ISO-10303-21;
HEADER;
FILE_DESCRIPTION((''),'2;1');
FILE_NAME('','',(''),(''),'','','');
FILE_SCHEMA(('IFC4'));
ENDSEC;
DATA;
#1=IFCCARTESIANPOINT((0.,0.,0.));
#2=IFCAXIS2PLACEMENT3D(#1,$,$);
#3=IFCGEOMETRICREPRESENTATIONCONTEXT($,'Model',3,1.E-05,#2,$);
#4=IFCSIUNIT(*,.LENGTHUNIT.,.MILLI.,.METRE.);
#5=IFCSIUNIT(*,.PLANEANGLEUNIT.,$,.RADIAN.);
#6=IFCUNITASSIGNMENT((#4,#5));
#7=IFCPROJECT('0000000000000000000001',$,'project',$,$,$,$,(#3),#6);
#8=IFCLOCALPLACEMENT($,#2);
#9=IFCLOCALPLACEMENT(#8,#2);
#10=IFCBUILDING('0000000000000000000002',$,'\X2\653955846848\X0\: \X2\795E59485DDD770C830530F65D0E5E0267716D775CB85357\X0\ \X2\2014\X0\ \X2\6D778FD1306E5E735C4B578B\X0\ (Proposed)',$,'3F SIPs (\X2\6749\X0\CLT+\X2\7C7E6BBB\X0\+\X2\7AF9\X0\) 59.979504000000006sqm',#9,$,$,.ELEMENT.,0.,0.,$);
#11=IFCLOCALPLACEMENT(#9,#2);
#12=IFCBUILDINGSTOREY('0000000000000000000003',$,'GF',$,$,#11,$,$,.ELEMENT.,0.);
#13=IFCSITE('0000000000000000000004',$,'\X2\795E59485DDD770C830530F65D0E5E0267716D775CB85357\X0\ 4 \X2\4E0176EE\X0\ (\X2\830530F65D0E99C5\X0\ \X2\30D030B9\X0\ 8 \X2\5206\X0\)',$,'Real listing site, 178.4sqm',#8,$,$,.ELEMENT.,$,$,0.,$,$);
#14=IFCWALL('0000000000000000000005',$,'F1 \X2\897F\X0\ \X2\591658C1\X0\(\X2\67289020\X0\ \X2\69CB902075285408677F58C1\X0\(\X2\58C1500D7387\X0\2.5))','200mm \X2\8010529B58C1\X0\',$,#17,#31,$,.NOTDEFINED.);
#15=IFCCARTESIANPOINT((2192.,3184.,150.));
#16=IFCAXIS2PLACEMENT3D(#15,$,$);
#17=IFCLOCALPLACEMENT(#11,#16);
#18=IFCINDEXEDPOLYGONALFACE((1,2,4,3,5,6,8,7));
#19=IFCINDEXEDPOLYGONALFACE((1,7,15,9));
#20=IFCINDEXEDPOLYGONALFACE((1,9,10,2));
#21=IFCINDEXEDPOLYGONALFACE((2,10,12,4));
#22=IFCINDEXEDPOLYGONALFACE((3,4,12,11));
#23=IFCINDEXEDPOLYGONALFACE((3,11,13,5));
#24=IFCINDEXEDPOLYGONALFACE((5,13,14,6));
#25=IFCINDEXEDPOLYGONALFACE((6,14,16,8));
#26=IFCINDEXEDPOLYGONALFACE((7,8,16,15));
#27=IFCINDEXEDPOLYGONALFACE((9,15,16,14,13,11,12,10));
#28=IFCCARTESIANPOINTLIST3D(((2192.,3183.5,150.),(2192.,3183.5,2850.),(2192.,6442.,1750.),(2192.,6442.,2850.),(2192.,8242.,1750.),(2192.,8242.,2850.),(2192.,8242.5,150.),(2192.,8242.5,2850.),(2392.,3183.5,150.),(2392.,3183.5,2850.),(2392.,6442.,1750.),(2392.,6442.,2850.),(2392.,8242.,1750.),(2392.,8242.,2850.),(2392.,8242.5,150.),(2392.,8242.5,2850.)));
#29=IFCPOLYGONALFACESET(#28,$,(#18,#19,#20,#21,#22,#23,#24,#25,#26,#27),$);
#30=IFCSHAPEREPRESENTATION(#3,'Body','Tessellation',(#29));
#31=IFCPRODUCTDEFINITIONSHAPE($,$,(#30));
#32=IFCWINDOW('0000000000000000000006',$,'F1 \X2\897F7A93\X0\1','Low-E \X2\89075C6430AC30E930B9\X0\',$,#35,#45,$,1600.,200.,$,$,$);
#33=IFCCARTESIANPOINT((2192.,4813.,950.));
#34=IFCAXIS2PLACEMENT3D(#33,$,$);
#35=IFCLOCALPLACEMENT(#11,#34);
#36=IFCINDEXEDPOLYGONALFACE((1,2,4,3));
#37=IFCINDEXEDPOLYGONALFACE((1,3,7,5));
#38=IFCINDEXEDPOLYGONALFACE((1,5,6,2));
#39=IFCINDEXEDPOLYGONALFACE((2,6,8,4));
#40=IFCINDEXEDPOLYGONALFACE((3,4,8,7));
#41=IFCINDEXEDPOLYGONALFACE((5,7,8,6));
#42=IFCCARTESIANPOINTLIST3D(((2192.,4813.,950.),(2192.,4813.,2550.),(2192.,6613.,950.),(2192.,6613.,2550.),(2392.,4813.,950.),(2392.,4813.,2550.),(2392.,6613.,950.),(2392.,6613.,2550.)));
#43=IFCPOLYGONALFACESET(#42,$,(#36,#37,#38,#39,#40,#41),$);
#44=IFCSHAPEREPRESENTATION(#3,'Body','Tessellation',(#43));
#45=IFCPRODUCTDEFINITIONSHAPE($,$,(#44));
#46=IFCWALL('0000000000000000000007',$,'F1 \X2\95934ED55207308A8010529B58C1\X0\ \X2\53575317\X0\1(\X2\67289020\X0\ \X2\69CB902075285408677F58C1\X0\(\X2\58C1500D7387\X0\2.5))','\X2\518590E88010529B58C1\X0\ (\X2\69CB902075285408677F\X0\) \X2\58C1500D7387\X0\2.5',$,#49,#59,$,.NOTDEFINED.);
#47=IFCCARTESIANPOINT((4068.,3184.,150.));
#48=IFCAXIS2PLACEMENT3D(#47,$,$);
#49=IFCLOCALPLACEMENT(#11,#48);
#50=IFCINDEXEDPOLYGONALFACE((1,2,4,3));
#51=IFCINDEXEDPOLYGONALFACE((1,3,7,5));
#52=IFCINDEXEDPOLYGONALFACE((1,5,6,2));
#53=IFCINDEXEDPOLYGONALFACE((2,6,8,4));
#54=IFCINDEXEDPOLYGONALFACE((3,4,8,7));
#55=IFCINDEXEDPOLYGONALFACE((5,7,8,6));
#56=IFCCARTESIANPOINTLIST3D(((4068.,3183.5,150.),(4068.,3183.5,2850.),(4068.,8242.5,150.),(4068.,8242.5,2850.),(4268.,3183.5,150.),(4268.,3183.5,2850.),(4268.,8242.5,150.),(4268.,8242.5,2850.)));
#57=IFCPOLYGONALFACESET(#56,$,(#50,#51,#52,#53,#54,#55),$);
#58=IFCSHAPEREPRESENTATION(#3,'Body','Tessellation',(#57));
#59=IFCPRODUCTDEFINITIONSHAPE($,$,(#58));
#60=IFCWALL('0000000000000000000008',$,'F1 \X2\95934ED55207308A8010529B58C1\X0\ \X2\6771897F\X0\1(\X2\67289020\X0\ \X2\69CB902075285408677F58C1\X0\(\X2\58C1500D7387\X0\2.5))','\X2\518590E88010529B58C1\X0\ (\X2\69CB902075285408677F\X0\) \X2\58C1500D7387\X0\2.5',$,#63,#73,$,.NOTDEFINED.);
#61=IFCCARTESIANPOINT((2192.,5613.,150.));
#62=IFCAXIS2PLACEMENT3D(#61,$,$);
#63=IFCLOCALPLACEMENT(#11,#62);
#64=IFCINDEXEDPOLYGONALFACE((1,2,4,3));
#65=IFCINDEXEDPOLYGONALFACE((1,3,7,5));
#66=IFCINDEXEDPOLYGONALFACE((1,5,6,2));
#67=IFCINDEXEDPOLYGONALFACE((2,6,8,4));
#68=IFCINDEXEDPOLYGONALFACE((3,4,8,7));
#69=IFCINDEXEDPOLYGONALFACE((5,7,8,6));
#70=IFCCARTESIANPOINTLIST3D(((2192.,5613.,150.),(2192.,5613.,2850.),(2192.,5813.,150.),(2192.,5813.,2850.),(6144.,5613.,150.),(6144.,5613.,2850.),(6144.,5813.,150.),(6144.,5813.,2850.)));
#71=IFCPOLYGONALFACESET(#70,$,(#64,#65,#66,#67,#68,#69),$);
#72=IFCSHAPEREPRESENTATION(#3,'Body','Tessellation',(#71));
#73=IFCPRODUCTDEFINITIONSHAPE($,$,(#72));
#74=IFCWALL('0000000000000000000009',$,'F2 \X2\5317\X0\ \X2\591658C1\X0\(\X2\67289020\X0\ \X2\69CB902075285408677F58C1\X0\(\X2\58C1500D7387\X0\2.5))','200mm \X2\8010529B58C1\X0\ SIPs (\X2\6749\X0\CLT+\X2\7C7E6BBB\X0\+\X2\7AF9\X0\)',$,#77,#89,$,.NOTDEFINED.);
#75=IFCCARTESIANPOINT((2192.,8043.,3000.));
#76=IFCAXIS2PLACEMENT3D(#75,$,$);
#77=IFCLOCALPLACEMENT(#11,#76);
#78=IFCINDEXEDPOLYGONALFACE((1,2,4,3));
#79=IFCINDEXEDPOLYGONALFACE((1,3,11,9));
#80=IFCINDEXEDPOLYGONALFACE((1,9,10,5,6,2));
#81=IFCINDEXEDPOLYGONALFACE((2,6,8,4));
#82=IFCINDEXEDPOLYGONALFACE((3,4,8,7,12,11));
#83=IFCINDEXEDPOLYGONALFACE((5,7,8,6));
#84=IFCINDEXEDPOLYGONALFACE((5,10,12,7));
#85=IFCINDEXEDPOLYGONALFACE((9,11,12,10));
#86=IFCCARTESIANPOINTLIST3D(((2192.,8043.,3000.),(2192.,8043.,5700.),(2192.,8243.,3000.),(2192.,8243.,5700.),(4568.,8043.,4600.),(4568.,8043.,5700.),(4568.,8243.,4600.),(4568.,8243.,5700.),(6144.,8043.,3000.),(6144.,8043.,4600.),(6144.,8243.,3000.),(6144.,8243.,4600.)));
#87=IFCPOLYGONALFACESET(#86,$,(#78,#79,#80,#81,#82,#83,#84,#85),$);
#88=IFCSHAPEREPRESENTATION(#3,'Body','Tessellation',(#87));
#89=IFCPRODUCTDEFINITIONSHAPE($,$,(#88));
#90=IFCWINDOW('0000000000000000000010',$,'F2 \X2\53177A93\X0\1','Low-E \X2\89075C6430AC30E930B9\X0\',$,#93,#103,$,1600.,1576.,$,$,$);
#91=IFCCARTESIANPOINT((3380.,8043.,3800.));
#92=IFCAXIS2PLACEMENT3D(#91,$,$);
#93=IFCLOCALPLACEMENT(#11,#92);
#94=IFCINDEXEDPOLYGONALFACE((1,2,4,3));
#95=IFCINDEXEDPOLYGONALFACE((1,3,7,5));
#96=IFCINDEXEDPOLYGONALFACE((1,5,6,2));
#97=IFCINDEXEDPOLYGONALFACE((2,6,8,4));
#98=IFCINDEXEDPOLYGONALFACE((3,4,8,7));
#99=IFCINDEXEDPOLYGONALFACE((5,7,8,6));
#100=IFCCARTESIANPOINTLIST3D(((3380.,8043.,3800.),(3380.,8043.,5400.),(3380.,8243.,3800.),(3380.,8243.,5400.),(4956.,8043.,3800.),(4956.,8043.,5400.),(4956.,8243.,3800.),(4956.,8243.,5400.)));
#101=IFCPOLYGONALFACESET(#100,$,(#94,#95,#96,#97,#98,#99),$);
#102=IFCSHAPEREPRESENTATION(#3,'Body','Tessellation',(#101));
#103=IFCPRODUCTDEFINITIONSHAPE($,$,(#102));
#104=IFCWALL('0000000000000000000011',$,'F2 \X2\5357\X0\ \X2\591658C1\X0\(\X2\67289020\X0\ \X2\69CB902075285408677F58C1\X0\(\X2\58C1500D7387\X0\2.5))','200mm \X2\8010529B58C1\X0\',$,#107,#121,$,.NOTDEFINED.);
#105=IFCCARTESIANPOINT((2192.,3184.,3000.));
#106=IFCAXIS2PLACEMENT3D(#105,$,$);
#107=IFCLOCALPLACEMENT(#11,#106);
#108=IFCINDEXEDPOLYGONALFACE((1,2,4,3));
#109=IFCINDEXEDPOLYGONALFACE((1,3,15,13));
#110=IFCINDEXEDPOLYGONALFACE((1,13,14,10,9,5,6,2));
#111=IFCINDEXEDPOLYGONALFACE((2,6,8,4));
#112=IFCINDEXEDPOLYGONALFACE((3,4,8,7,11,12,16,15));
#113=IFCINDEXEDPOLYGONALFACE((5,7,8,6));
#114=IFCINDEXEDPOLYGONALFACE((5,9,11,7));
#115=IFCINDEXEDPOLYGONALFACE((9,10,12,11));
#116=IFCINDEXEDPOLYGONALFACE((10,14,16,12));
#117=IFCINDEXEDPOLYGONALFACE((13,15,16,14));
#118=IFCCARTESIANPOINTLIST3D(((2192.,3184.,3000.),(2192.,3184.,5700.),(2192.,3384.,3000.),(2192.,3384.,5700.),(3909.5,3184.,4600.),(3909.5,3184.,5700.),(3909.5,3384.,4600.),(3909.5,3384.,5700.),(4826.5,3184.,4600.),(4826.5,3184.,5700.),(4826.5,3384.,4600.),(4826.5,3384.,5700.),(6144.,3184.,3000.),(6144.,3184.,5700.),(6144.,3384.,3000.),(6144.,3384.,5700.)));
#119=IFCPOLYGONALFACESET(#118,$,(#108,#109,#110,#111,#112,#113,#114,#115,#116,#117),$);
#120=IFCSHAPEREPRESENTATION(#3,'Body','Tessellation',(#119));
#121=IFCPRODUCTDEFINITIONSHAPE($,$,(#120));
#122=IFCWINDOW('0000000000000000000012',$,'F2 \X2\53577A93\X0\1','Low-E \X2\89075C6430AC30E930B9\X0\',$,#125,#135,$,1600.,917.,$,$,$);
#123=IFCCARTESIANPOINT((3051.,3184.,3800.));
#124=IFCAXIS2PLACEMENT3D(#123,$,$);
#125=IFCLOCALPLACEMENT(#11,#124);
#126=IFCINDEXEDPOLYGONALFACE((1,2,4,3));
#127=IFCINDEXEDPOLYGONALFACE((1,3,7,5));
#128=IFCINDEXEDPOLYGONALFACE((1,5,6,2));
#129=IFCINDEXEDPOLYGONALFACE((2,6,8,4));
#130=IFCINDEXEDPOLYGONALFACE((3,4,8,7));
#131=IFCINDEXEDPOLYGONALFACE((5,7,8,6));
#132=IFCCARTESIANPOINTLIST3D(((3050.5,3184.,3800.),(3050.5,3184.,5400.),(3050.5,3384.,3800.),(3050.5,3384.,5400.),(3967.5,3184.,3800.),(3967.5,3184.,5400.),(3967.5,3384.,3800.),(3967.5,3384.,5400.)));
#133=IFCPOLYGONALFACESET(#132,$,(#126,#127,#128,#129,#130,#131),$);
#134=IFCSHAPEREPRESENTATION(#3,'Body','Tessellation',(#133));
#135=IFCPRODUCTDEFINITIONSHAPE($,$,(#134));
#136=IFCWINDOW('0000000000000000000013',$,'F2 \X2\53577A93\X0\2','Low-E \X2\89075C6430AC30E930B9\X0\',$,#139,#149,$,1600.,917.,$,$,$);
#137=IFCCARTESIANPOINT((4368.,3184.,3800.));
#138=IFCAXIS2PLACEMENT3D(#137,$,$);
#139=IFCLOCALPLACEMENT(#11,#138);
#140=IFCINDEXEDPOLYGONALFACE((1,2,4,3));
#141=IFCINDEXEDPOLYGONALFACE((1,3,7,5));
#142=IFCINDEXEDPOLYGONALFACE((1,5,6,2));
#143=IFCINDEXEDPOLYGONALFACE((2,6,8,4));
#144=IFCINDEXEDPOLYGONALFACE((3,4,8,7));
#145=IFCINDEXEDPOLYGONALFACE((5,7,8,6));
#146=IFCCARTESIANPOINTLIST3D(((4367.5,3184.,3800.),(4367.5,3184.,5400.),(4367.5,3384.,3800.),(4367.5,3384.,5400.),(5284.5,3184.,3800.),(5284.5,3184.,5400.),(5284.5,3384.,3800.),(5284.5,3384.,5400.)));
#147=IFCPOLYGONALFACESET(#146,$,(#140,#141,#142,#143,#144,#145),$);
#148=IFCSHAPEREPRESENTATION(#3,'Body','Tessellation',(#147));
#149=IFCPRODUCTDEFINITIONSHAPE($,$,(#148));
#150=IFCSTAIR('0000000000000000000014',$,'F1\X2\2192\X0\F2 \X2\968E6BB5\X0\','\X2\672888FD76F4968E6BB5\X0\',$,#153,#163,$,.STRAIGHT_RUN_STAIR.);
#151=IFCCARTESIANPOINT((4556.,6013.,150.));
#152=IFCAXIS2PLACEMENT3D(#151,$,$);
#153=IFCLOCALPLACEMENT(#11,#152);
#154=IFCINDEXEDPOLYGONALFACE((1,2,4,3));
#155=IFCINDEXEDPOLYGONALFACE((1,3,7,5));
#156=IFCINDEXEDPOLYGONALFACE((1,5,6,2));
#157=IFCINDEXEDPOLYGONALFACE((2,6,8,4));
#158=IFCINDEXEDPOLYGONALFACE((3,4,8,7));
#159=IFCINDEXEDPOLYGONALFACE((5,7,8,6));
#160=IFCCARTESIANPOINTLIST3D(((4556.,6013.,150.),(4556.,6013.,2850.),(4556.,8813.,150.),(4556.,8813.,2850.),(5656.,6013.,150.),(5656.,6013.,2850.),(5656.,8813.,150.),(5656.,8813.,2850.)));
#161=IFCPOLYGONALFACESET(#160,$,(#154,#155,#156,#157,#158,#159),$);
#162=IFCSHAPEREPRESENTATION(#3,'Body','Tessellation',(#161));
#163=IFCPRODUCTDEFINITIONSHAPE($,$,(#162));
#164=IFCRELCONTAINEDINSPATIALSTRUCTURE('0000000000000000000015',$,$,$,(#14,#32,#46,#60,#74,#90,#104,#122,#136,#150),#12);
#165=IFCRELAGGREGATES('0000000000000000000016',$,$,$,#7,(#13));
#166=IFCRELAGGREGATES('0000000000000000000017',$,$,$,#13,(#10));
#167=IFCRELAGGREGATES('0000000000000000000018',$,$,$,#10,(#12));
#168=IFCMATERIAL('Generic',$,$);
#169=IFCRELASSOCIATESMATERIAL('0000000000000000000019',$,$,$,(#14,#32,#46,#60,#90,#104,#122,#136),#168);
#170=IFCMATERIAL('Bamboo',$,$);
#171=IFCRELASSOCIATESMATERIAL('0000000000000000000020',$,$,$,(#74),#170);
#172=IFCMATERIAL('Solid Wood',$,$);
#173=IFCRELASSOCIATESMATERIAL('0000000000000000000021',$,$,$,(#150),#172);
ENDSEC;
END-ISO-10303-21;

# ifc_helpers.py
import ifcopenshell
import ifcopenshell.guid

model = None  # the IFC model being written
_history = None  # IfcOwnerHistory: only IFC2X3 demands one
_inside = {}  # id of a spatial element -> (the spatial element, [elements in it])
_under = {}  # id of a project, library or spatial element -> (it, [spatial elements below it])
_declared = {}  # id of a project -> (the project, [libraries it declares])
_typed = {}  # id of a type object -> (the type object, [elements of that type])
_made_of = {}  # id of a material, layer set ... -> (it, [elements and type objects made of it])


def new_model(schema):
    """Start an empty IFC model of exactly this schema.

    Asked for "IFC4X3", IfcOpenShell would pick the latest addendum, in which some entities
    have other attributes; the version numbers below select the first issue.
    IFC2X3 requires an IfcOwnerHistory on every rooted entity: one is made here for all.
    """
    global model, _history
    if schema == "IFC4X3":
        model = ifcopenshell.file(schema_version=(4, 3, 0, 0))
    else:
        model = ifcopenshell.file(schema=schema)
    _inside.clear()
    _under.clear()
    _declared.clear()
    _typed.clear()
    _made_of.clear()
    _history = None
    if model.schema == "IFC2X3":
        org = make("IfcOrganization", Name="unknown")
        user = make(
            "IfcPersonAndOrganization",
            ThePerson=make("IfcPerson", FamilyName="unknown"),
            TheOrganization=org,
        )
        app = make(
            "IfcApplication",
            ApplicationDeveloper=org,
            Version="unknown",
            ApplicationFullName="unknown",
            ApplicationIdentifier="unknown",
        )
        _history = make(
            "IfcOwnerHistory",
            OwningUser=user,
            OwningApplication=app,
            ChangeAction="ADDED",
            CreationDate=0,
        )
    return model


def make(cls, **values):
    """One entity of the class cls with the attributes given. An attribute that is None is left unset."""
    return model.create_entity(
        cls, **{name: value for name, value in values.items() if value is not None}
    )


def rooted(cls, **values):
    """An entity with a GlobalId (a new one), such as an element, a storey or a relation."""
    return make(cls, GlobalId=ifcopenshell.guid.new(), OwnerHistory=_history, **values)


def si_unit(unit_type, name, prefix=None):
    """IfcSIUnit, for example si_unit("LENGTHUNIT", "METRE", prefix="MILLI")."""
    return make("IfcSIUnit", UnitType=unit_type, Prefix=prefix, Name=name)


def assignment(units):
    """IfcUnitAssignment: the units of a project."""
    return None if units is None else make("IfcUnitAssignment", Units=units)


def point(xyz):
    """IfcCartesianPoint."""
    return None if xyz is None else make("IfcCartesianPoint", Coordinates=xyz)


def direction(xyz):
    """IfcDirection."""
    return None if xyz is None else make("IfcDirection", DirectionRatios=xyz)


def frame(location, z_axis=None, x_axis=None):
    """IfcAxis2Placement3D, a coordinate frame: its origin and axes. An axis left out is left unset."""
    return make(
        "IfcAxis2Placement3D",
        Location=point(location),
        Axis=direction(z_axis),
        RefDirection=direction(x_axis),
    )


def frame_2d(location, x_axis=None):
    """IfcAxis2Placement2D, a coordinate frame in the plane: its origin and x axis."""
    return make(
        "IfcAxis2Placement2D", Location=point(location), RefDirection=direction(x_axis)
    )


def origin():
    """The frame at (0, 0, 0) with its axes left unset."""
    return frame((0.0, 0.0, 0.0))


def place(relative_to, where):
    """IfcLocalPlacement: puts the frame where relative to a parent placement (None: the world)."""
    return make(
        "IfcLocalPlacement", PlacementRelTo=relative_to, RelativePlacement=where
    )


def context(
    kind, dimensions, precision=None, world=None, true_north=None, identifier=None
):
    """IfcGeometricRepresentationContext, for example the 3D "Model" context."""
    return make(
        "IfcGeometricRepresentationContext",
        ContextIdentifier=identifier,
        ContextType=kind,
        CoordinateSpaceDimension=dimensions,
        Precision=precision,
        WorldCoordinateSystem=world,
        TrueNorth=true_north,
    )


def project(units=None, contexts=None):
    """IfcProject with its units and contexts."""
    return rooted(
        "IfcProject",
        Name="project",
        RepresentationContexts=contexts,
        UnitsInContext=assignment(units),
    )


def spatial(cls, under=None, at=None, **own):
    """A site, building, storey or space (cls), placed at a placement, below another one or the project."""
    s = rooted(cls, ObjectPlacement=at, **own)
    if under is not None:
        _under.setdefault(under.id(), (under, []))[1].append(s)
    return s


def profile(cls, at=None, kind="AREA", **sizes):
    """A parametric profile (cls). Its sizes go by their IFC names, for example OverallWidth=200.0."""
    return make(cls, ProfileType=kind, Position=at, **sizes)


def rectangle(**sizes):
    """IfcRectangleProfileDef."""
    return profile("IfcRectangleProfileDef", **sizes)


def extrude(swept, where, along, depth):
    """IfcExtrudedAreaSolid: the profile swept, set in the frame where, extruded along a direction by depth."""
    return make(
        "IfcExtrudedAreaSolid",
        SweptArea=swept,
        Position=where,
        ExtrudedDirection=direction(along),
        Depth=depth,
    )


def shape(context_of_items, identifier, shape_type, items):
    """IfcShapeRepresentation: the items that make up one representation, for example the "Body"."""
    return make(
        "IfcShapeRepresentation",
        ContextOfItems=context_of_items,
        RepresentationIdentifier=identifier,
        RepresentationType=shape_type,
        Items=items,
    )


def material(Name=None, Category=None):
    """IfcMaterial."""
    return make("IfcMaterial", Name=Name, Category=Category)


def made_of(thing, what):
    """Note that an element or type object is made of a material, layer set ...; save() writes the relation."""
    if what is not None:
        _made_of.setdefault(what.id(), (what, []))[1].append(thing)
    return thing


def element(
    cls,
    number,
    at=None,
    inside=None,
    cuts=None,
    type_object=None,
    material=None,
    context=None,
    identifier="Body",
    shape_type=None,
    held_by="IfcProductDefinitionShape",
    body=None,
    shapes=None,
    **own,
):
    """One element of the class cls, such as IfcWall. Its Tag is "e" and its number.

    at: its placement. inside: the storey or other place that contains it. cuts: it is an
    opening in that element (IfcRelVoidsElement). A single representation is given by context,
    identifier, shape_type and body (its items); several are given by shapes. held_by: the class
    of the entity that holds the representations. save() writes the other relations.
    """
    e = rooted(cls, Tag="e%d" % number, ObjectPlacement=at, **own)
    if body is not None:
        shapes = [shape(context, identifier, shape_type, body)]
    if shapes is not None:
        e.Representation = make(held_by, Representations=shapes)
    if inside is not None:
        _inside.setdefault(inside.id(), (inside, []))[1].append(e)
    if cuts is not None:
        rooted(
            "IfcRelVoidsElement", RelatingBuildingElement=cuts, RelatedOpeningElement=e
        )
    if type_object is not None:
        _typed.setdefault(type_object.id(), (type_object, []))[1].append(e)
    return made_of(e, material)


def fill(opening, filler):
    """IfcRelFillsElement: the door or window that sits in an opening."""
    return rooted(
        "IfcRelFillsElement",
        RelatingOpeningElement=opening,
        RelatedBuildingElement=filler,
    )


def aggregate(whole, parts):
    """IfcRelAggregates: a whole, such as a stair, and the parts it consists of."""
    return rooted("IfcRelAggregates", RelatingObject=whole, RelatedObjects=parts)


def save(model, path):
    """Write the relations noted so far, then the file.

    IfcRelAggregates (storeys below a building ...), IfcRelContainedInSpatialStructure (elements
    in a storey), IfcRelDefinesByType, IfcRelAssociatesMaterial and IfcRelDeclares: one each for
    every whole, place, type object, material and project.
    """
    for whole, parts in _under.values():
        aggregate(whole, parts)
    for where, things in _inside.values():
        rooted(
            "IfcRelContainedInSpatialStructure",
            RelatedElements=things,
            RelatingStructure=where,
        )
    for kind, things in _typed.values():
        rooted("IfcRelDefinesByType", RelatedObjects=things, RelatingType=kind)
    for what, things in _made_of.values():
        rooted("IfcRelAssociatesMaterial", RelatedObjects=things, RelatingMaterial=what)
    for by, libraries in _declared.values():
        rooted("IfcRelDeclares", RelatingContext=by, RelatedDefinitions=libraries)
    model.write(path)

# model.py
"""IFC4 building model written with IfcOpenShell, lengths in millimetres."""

from ifc_helpers import new_model, si_unit, frame, frame_2d, origin, place, context, project, spatial, rectangle, extrude, material, element, fill, save


model = new_model("IFC4")

# Units and contexts
model_context = context("Model", 3, precision=1e-05, world=origin())
ifc_project = project(units=[si_unit("LENGTHUNIT", "METRE", prefix="MILLI"), si_unit("PLANEANGLEUNIT", "RADIAN")], contexts=[model_context])

# Site, building, storey
site_placement = place(None, origin())
site = spatial("IfcSite", under=ifc_project, at=site_placement, Name="神奈川県茅ヶ崎市東海岸南 4 丁目 (茅ヶ崎駅 バス 8 分)", ObjectType="Real listing site, 178.4sqm", CompositionType="ELEMENT", RefElevation=0.0)
building_placement = place(site_placement, origin())
building = spatial("IfcBuilding", under=site, at=building_placement, Name="改善案: 神奈川県茅ヶ崎市東海岸南 — 海近の平屋型 (Proposed)", ObjectType="3F SIPs (杉CLT+籾殻+竹) 59.979504000000006sqm", CompositionType="ELEMENT", ElevationOfRefHeight=0.0, ElevationOfTerrain=0.0)
storey_placement = place(building_placement, origin())
storey = spatial("IfcBuildingStorey", under=building, at=storey_placement, Name="GF", CompositionType="ELEMENT", Elevation=0.0)

# Shared definitions
ifc_material_1 = material(Name="Generic")

# Shared definitions
ifc_material_2 = material(Name="Bamboo")

# Shared definitions
ifc_material_3 = material(Name="Solid Wood")

# Wall, opening, window
wall_1_placement = place(storey_placement, frame((2192.0, 3184.0, 150.0)))
wall_1 = element("IfcWall", 1, at=wall_1_placement, inside=storey, material=ifc_material_1, Name="F1 西 外壁(木造 構造用合板壁(壁倍率2.5))", Description="200mm 耐力壁", PredefinedType="NOTDEFINED", context=model_context, shape_type="SweptSolid", body=[
    extrude(rectangle(XDim=200.0, YDim=5059.0, at=frame_2d((100.0, 2529.0))), frame((2192.0, 3184.0, 150.0)), (0.0, 0.0, 1.0), 2700.0),
])
opening_1_placement = place(storey_placement, frame((2192.0, 4813.0, 950.0)))
opening_1 = element("IfcOpeningElement", 2, at=opening_1_placement, cuts=wall_1, PredefinedType="NOTDEFINED", context=model_context, shape_type="SweptSolid", body=[
    extrude(rectangle(XDim=200.0, YDim=1800.0, at=frame_2d((100.0, 900.0))), frame((2192.0, 4813.0, 950.0)), (0.0, 0.0, 1.0), 1600.0),
])
window_1_placement = place(storey_placement, frame((2192.0, 4813.0, 950.0)))
window_1 = element("IfcWindow", 3, at=window_1_placement, inside=storey, material=ifc_material_1, Name="F1 西窓1", Description="Low-E 複層ガラス", OverallHeight=1600.0, OverallWidth=200.0, context=model_context, shape_type="SweptSolid", body=[
    extrude(rectangle(XDim=200.0, YDim=1800.0, at=frame_2d((100.0, 900.0))), frame((2192.0, 4813.0, 950.0)), (0.0, 0.0, 1.0), 1600.0),
])
fill(opening_1, window_1)

# Walls
wall_2_placement = place(storey_placement, frame((4068.0, 3184.0, 150.0)))
element("IfcWall", 4, at=wall_2_placement, inside=storey, material=ifc_material_1, Name="F1 間仕切り耐力壁 南北1(木造 構造用合板壁(壁倍率2.5))", Description="内部耐力壁 (構造用合板) 壁倍率2.5", PredefinedType="NOTDEFINED", context=model_context, shape_type="SweptSolid", body=[
    extrude(rectangle(XDim=200.0, YDim=5059.0, at=frame_2d((100.0, 2529.0))), frame((4068.0, 3184.0, 150.0)), (0.0, 0.0, 1.0), 2700.0),
])
wall_3_placement = place(storey_placement, frame((2192.0, 5613.0, 150.0)))
element("IfcWall", 5, at=wall_3_placement, inside=storey, material=ifc_material_1, Name="F1 間仕切り耐力壁 東西1(木造 構造用合板壁(壁倍率2.5))", Description="内部耐力壁 (構造用合板) 壁倍率2.5", PredefinedType="NOTDEFINED", context=model_context, shape_type="SweptSolid", body=[
    extrude(rectangle(XDim=3952.0, YDim=200.0, at=frame_2d((1976.0, 100.0))), frame((2192.0, 5613.0, 150.0)), (0.0, 0.0, 1.0), 2700.0),
])

# Wall, opening, window
wall_4_placement = place(storey_placement, frame((2192.0, 8043.0, 3000.0)))
wall_4 = element("IfcWall", 6, at=wall_4_placement, inside=storey, material=ifc_material_2, Name="F2 北 外壁(木造 構造用合板壁(壁倍率2.5))", Description="200mm 耐力壁 SIPs (杉CLT+籾殻+竹)", PredefinedType="NOTDEFINED", context=model_context, shape_type="SweptSolid", body=[
    extrude(rectangle(XDim=3952.0, YDim=200.0, at=frame_2d((1976.0, 100.0))), frame((2192.0, 8043.0, 3000.0)), (0.0, 0.0, 1.0), 2700.0),
])
opening_2_placement = place(storey_placement, frame((3380.0, 8043.0, 3800.0)))
opening_2 = element("IfcOpeningElement", 7, at=opening_2_placement, cuts=wall_4, PredefinedType="NOTDEFINED", context=model_context, shape_type="SweptSolid", body=[
    extrude(rectangle(XDim=1576.0, YDim=200.0, at=frame_2d((788.0, 100.0))), frame((3380.0, 8043.0, 3800.0)), (0.0, 0.0, 1.0), 1600.0),
])
window_2_placement = place(storey_placement, frame((3380.0, 8043.0, 3800.0)))
window_2 = element("IfcWindow", 8, at=window_2_placement, inside=storey, material=ifc_material_1, Name="F2 北窓1", Description="Low-E 複層ガラス", OverallHeight=1600.0, OverallWidth=1576.0, context=model_context, shape_type="SweptSolid", body=[
    extrude(rectangle(XDim=1576.0, YDim=200.0, at=frame_2d((788.0, 100.0))), frame((3380.0, 8043.0, 3800.0)), (0.0, 0.0, 1.0), 1600.0),
])
fill(opening_2, window_2)

# Wall, openings, windows
wall_5_placement = place(storey_placement, frame((2192.0, 3184.0, 3000.0)))
wall_5 = element("IfcWall", 9, at=wall_5_placement, inside=storey, material=ifc_material_1, Name="F2 南 外壁(木造 構造用合板壁(壁倍率2.5))", Description="200mm 耐力壁", PredefinedType="NOTDEFINED", context=model_context, shape_type="SweptSolid", body=[
    extrude(rectangle(XDim=3952.0, YDim=200.0, at=frame_2d((1976.0, 100.0))), frame((2192.0, 3184.0, 3000.0)), (0.0, 0.0, 1.0), 2700.0),
])
opening_3_placement = place(storey_placement, frame((3051.0, 3184.0, 3800.0)))
opening_3 = element("IfcOpeningElement", 10, at=opening_3_placement, cuts=wall_5, PredefinedType="NOTDEFINED", context=model_context, shape_type="SweptSolid", body=[
    extrude(rectangle(XDim=917.0, YDim=200.0, at=frame_2d((458.0, 100.0))), frame((3051.0, 3184.0, 3800.0)), (0.0, 0.0, 1.0), 1600.0),
])
opening_4_placement = place(storey_placement, frame((4368.0, 3184.0, 3800.0)))
opening_4 = element("IfcOpeningElement", 11, at=opening_4_placement, cuts=wall_5, PredefinedType="NOTDEFINED", context=model_context, shape_type="SweptSolid", body=[
    extrude(rectangle(XDim=917.0, YDim=200.0, at=frame_2d((458.0, 100.0))), frame((4368.0, 3184.0, 3800.0)), (0.0, 0.0, 1.0), 1600.0),
])
window_3_placement = place(storey_placement, frame((3051.0, 3184.0, 3800.0)))
window_3 = element("IfcWindow", 12, at=window_3_placement, inside=storey, material=ifc_material_1, Name="F2 南窓1", Description="Low-E 複層ガラス", OverallHeight=1600.0, OverallWidth=917.0, context=model_context, shape_type="SweptSolid", body=[
    extrude(rectangle(XDim=917.0, YDim=200.0, at=frame_2d((458.0, 100.0))), frame((3051.0, 3184.0, 3800.0)), (0.0, 0.0, 1.0), 1600.0),
])
fill(opening_3, window_3)
window_4_placement = place(storey_placement, frame((4368.0, 3184.0, 3800.0)))
window_4 = element("IfcWindow", 13, at=window_4_placement, inside=storey, material=ifc_material_1, Name="F2 南窓2", Description="Low-E 複層ガラス", OverallHeight=1600.0, OverallWidth=917.0, context=model_context, shape_type="SweptSolid", body=[
    extrude(rectangle(XDim=917.0, YDim=200.0, at=frame_2d((458.0, 100.0))), frame((4368.0, 3184.0, 3800.0)), (0.0, 0.0, 1.0), 1600.0),
])
fill(opening_4, window_4)

# Stair
stair_placement = place(storey_placement, frame((4556.0, 6013.0, 150.0)))
element("IfcStair", 14, at=stair_placement, inside=storey, material=ifc_material_3, Name="F1→F2 階段", Description="木製直階段", PredefinedType="STRAIGHT_RUN_STAIR", context=model_context, shape_type="SweptSolid", body=[
    extrude(rectangle(XDim=1100.0, YDim=2800.0, at=frame_2d((550.0, 1400.0))), frame((4556.0, 6013.0, 150.0)), (0.0, 0.0, 1.0), 2700.0),
])

save(model, "model.ifc")
